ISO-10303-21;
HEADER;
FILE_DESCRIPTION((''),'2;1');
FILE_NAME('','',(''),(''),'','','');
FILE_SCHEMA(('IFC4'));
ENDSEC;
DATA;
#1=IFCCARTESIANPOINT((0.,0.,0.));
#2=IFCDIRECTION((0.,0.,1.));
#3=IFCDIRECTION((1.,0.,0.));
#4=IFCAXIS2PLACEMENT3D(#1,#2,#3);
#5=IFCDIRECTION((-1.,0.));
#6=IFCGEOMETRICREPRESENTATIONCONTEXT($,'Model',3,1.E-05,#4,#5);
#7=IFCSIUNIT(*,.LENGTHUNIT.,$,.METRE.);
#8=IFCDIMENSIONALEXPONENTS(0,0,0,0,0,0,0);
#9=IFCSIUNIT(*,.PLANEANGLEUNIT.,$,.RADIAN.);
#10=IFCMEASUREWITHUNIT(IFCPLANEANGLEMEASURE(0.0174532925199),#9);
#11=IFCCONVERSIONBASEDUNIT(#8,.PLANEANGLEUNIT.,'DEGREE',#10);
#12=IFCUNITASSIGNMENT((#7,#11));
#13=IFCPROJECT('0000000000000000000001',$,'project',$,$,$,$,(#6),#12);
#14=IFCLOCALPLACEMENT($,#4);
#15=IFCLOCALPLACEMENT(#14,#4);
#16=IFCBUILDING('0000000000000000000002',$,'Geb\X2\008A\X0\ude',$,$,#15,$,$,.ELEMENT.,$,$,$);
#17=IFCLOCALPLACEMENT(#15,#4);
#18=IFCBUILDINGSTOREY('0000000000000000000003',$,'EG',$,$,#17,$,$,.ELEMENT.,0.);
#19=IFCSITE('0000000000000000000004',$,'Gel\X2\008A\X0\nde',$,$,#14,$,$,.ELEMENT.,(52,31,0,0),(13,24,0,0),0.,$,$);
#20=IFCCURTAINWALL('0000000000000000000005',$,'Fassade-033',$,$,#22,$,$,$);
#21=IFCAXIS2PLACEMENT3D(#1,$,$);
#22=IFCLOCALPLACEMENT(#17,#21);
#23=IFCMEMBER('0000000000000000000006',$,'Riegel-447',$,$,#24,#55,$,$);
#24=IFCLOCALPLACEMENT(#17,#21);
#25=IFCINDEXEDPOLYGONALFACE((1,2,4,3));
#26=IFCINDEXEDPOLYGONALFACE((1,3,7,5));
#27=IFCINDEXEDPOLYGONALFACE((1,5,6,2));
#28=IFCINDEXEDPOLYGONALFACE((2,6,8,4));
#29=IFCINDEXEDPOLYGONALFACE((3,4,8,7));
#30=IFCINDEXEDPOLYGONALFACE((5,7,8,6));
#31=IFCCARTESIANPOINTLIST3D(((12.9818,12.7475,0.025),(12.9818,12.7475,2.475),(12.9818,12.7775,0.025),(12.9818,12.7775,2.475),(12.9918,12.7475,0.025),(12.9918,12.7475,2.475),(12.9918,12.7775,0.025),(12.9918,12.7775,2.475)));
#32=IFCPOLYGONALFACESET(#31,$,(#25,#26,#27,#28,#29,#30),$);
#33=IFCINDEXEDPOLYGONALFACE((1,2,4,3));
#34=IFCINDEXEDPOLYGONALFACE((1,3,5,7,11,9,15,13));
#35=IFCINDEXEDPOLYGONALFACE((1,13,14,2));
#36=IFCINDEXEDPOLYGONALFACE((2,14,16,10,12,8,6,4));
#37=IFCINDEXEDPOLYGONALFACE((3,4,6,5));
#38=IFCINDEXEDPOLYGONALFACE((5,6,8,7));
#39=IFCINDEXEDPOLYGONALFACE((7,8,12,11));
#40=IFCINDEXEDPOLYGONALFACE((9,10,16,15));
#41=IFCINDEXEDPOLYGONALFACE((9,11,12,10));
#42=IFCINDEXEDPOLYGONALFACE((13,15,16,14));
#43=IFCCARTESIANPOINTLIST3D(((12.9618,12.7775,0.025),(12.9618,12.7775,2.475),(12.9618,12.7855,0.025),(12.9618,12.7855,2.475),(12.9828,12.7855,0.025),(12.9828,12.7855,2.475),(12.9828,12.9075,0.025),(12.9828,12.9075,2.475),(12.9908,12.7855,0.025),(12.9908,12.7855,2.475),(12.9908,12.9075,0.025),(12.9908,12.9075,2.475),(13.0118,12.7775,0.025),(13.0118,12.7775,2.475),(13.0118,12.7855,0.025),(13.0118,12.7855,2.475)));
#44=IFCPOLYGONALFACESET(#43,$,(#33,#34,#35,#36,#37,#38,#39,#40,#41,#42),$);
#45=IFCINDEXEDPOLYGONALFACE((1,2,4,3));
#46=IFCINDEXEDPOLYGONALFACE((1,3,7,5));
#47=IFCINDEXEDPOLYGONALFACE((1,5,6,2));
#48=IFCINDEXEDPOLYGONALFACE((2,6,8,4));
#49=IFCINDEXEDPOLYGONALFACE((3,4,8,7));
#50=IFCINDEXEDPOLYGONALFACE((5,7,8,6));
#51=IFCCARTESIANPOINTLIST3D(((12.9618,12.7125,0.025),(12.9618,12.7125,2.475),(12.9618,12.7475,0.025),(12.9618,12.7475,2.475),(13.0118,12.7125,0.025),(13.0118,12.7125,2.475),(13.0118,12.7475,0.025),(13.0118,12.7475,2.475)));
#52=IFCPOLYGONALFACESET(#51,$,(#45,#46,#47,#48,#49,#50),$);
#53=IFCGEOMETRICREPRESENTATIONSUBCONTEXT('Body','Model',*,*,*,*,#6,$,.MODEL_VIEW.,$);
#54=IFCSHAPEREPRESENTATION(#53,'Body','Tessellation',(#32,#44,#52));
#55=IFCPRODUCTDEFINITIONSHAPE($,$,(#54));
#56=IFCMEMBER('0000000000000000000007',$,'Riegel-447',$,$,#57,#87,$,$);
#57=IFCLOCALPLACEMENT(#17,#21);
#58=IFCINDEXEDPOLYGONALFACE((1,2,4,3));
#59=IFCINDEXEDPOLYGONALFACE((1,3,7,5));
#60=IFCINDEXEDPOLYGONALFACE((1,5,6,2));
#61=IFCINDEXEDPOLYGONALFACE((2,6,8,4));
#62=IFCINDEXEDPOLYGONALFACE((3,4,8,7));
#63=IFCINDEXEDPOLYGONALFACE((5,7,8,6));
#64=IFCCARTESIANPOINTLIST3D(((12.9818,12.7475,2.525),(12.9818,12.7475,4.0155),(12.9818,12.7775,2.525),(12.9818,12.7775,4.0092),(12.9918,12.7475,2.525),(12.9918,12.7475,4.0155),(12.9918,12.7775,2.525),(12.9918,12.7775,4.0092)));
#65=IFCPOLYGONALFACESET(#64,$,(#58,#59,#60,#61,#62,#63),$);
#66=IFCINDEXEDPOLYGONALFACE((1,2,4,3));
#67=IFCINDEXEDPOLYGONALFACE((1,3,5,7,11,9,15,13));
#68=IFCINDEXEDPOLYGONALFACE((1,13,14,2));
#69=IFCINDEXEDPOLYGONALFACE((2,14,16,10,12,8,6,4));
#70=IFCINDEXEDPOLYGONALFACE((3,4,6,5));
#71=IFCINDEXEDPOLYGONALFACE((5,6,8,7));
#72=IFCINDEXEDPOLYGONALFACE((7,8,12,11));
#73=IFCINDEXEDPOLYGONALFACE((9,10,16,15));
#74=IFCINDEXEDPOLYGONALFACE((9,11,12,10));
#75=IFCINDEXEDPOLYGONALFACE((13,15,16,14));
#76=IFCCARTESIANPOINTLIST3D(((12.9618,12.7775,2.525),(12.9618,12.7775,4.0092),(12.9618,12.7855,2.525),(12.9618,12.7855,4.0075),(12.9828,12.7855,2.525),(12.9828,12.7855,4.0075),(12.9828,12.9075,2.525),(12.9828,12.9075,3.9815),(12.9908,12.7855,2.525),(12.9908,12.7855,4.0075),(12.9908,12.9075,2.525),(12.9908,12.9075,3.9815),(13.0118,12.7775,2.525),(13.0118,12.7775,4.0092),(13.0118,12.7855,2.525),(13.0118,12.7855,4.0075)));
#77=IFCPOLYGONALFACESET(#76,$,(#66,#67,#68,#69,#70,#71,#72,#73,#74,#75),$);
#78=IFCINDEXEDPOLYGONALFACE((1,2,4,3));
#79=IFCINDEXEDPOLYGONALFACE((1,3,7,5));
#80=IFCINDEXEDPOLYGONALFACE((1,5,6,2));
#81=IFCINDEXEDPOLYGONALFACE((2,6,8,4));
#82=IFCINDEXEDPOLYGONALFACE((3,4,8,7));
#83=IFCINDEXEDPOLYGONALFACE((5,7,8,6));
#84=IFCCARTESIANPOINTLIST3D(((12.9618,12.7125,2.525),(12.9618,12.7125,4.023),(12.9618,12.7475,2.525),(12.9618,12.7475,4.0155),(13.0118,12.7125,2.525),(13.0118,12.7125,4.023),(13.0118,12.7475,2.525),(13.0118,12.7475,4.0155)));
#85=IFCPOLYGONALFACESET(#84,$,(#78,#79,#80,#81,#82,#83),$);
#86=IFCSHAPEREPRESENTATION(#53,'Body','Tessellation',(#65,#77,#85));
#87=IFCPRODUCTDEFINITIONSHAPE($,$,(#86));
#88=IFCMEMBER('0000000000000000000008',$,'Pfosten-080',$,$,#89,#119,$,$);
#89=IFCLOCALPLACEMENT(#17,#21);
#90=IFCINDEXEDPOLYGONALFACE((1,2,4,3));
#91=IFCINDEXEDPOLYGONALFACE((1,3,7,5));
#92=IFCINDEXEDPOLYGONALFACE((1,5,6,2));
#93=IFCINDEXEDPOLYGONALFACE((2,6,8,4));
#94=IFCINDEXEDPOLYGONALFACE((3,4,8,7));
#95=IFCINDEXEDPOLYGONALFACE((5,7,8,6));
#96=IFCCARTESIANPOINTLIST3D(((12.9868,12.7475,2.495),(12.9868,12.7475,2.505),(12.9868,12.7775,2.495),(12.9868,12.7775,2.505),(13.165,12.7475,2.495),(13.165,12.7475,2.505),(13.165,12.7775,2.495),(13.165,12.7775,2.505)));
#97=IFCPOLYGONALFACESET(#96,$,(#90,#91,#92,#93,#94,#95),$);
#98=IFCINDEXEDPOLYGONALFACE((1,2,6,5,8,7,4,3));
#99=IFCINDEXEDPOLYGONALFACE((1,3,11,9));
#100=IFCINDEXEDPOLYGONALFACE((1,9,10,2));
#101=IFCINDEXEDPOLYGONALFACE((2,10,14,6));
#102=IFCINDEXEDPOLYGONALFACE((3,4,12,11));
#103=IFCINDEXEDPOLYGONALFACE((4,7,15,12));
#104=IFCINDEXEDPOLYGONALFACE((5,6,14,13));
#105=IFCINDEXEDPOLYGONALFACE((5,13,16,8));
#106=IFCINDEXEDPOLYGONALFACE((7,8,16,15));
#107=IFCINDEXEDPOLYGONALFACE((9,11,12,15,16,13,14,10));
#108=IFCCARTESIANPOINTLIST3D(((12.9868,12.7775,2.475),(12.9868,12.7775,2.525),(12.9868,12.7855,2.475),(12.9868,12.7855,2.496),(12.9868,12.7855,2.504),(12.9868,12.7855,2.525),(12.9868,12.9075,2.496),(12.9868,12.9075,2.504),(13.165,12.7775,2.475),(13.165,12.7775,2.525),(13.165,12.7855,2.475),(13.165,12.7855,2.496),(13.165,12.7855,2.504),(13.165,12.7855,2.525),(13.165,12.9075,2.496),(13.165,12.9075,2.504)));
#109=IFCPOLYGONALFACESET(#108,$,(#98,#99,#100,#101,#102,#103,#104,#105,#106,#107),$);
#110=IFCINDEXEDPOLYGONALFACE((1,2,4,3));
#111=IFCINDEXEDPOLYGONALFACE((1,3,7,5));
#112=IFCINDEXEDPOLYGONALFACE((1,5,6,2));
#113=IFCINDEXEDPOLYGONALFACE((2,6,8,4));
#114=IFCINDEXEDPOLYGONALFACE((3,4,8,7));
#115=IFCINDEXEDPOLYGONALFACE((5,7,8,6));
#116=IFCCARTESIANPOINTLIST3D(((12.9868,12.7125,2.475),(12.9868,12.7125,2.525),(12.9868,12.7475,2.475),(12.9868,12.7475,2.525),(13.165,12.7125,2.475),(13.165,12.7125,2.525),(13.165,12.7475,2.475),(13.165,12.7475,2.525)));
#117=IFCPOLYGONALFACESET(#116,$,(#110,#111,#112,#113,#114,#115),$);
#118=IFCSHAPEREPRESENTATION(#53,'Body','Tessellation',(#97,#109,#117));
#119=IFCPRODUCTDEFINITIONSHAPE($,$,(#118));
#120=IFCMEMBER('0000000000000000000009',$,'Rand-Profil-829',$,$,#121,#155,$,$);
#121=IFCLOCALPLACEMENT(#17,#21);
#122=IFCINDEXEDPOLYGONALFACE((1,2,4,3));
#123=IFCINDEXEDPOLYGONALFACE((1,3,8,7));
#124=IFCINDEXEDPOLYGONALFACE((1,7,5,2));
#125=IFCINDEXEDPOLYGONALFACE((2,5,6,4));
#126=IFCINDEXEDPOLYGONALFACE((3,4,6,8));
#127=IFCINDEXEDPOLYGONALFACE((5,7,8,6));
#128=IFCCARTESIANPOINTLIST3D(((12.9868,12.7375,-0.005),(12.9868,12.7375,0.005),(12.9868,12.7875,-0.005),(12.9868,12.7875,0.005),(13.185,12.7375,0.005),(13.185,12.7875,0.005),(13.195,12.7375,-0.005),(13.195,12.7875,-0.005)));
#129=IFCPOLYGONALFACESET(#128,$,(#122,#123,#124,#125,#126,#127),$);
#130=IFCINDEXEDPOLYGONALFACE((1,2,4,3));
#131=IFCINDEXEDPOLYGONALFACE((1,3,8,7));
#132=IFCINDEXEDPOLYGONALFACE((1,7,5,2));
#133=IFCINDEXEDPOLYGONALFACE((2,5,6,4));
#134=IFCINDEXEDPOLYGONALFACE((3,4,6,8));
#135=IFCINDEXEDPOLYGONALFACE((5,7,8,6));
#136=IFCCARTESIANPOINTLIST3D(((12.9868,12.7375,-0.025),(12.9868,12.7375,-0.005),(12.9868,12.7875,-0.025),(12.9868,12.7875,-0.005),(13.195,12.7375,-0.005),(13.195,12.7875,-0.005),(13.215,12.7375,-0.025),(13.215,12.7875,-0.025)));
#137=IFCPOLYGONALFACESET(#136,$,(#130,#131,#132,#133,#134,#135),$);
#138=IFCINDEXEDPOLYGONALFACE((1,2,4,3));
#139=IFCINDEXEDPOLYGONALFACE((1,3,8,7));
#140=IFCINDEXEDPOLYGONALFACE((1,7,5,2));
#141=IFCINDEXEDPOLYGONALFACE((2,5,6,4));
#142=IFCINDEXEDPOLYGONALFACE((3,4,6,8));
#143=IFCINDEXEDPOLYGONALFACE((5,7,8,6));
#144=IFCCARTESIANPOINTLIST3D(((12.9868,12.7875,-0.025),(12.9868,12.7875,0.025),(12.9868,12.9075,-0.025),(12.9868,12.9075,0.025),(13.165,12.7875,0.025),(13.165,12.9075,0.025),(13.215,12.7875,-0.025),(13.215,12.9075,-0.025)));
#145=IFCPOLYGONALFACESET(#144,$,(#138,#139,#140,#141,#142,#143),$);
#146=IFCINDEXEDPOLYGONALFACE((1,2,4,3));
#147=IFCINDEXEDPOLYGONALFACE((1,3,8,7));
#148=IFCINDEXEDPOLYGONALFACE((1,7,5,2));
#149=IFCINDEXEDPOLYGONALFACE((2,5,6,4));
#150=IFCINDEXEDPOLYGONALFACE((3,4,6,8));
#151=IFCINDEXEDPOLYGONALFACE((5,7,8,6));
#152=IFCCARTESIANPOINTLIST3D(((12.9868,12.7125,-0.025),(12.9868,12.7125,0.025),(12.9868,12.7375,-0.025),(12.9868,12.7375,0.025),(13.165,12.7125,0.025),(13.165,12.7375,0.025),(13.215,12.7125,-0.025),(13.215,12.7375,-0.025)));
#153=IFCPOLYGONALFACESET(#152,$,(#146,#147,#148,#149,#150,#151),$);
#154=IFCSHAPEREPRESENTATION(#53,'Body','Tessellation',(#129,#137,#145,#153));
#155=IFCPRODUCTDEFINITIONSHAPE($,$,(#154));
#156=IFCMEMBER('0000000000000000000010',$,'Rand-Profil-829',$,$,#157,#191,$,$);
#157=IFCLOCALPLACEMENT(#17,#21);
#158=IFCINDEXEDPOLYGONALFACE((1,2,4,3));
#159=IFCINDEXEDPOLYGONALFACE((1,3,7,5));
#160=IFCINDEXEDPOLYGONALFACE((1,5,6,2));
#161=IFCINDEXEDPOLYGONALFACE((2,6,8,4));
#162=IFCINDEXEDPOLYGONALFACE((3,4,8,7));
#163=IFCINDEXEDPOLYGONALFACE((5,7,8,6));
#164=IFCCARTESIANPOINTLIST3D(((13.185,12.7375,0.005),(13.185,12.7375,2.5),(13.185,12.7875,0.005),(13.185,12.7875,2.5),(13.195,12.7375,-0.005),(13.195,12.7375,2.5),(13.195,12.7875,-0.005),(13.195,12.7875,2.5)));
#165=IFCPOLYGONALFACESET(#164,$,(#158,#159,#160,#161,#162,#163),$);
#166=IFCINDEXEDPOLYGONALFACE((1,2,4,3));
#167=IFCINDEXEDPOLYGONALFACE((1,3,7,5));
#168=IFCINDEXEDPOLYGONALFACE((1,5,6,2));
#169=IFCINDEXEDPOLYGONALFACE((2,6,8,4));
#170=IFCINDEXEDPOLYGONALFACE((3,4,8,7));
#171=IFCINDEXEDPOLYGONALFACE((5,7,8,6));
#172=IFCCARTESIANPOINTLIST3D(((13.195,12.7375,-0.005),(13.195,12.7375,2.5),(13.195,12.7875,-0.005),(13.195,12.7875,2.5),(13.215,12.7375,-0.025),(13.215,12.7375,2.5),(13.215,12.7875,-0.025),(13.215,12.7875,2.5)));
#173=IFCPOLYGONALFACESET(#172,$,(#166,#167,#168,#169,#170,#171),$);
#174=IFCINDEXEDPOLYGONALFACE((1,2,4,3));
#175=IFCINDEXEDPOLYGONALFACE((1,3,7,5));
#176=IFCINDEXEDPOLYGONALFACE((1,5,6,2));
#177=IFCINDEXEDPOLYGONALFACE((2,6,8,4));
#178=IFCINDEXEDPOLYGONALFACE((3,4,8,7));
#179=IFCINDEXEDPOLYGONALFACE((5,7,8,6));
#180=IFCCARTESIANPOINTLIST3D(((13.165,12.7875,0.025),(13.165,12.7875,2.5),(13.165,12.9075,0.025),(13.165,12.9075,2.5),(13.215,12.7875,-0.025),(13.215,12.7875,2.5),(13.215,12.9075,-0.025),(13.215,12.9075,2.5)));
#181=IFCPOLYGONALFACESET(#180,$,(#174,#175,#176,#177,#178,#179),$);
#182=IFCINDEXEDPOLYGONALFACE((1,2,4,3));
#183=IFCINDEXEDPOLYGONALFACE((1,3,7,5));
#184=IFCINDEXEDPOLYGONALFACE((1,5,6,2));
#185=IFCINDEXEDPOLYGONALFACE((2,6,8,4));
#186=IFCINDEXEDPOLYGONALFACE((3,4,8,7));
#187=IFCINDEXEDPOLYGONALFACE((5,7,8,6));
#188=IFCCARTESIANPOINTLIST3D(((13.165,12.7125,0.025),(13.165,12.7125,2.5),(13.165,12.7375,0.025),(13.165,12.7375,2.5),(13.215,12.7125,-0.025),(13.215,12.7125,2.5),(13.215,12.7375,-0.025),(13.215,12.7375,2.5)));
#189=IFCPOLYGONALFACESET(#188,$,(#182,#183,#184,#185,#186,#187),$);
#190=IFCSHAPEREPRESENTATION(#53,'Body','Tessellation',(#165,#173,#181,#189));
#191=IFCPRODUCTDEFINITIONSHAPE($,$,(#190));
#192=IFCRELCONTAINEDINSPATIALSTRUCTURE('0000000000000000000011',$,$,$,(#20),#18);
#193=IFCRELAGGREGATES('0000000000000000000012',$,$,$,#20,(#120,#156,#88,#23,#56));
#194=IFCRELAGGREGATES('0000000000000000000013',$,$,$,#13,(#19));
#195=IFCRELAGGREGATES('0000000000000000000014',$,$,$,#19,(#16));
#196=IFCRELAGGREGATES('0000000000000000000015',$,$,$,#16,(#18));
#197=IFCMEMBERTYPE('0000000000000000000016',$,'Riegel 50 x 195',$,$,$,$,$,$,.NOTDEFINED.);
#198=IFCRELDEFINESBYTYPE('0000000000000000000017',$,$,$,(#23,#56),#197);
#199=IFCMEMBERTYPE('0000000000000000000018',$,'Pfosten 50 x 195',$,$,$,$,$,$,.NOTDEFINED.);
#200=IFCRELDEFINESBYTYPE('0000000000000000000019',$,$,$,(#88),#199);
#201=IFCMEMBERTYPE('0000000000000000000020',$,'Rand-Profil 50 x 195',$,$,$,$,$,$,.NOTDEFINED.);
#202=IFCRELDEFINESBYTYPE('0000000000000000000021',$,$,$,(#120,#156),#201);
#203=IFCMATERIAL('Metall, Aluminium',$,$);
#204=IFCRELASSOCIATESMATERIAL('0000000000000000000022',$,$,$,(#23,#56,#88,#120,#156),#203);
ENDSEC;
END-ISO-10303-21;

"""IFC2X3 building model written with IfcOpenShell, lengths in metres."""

from ifc_helpers import new_model, entity, si_unit, converted_unit, direction, frame, origin_with_axes, place, context, subcontext, project, spatial, polyline, outline, extrude, clip, halfspace, material, type_object, element, aggregate, save


model = new_model("IFC2X3")

# Units and contexts
model_context = context("Model", 3, precision=1e-05, world=origin_with_axes(), true_north=direction((-1.0, 0.0)))
body_context = subcontext(model_context, "Body", "Model", "MODEL_VIEW")
ifc_project = project(units=[si_unit("LENGTHUNIT", "METRE"), converted_unit("PLANEANGLEUNIT", "DEGREE", entity("IfcPlaneAngleMeasure", 0.0174532925199), si_unit("PLANEANGLEUNIT", "RADIAN"), dimensions=[0, 0, 0, 0, 0, 0, 0])], contexts=[model_context])

# Site, building, storey
site_placement = place(None, origin_with_axes())
site = spatial("IfcSite", under=ifc_project, at=site_placement, Name="Gel\u008ande", CompositionType="ELEMENT", RefLatitude=(52, 31, 0, 0), RefLongitude=(13, 24, 0, 0), RefElevation=0.0)
building_placement = place(site_placement, origin_with_axes())
building = spatial("IfcBuilding", under=site, at=building_placement, Name="Geb\u008aude", CompositionType="ELEMENT")
storey_placement = place(building_placement, origin_with_axes())
storey = spatial("IfcBuildingStorey", under=building, at=storey_placement, Name="EG", CompositionType="ELEMENT", Elevation=0.0)

# Curtain wall, members
curtain_wall_1_placement = place(storey_placement, frame((12.3938, 12.7625, 0.0), z_axis=(0.0, 0.0, 1.0), x_axis=(1.0, 0.0, 0.0)))
curtain_wall_1 = element("IfcCurtainWall", 1, at=curtain_wall_1_placement, inside=storey, Name="Fassade-033")
ifc_material_1 = material(Name="Metall, Aluminium")
member_type_1 = type_object("IfcMemberType", Name="Riegel 50 x 195", PredefinedType="NOTDEFINED")
member_1_placement = place(curtain_wall_1_placement, frame((0.593, 0.0, 0.0), z_axis=(0.0, 0.0, 1.0), x_axis=(-1.0, 0.0, 0.0)))
member_1 = element("IfcMember", 2, at=member_1_placement, type_object=member_type_1, material=ifc_material_1, Name="Riegel-447", context=body_context, shape_type="SweptSolid", body=[
    extrude(outline(polyline([(-0.005, 0.015), (-0.005, -0.015), (0.005, -0.015), (0.005, 0.015), (-0.005, 0.015)])), frame((0.0, 0.0, 0.025), z_axis=(0.0, 0.0, 1.0), x_axis=(-1.0, 0.0, 0.0)), (0.0, 0.0, 1.0), 2.45),
    extrude(outline(polyline([(-0.004, 0.145), (-0.004, 0.023), (-0.025, 0.023), (-0.025, 0.015), (0.025, 0.015), (0.025, 0.023), (0.004, 0.023), (0.004, 0.145), (-0.004, 0.145)])), frame((0.0, 0.0, 0.025), z_axis=(0.0, 0.0, 1.0), x_axis=(-1.0, 0.0, 0.0)), (0.0, 0.0, 1.0), 2.45),
    extrude(outline(polyline([(0.025, -0.05), (0.025, -0.015), (-0.025, -0.015), (-0.025, -0.05), (0.025, -0.05)])), frame((0.0, 0.0, 0.025), z_axis=(0.0, 0.0, 1.0), x_axis=(-1.0, 0.0, 0.0)), (0.0, 0.0, 1.0), 2.45),
])
member_2_placement = place(curtain_wall_1_placement, frame((0.593, 0.0, 2.5), z_axis=(0.0, 0.0, 1.0), x_axis=(-1.0, 0.0, 0.0)))
member_2 = element("IfcMember", 3, at=member_2_placement, type_object=member_type_1, material=ifc_material_1, Name="Riegel-447", context=body_context, shape_type="Clipping", body=[
    clip(extrude(outline(polyline([(0.005, 0.015), (-0.005, 0.015), (-0.005, -0.015), (0.005, -0.015), (0.005, 0.015)])), frame((0.0, 0.0, 0.025), z_axis=(0.0, 0.0, 1.0), x_axis=(-1.0, 0.0, 0.0)), (0.0, 0.0, 1.0), 1.4905), halfspace(frame((0.0, -0.3076, 1.447), z_axis=(0.0, 0.207912, -0.978148), x_axis=(0.0, -0.978148, -0.207912)), True)),
    clip(extrude(outline(polyline([(0.025, 0.023), (0.004, 0.023), (0.004, 0.145), (-0.004, 0.145), (-0.004, 0.023), (-0.025, 0.023), (-0.025, 0.015), (0.025, 0.015), (0.025, 0.023)])), frame((0.0, 0.0, 0.025), z_axis=(0.0, 0.0, 1.0), x_axis=(-1.0, 0.0, 0.0)), (0.0, 0.0, 1.0), 1.4842), halfspace(frame((0.0, -0.3076, 1.447), z_axis=(0.0, 0.207912, -0.978148), x_axis=(0.0, -0.978148, -0.207912)), True)),
    clip(extrude(outline(polyline([(0.025, -0.015), (-0.025, -0.015), (-0.025, -0.05), (0.025, -0.05), (0.025, -0.015)])), frame((0.0, 0.0, 0.025), z_axis=(0.0, 0.0, 1.0), x_axis=(-1.0, 0.0, 0.0)), (0.0, 0.0, 1.0), 1.498), halfspace(frame((0.0, -0.3076, 1.447), z_axis=(0.0, 0.207912, -0.978148), x_axis=(0.0, -0.978148, -0.207912)), True)),
])
member_type_2 = type_object("IfcMemberType", Name="Pfosten 50 x 195", PredefinedType="NOTDEFINED")
member_3_placement = place(curtain_wall_1_placement, frame((0.593, 0.0, 2.5), z_axis=(1.0, 0.0, 0.0), x_axis=(0.0, 0.0, 1.0)))
member_3 = element("IfcMember", 4, at=member_3_placement, type_object=member_type_2, material=ifc_material_1, Name="Pfosten-080", context=body_context, shape_type="SweptSolid", body=[
    extrude(outline(polyline([(-0.015, -0.005), (0.015, -0.005), (0.015, 0.005), (-0.015, 0.005), (-0.015, -0.005)])), frame((0.0, 0.0, 0.0), z_axis=(0.0, 0.0, 1.0), x_axis=(0.0, 1.0, 0.0)), (0.0, 0.0, 1.0), 0.1782),
    extrude(outline(polyline([(-0.145, -0.004), (-0.023, -0.004), (-0.023, -0.025), (-0.015, -0.025), (-0.015, 0.025), (-0.023, 0.025), (-0.023, 0.004), (-0.145, 0.004), (-0.145, -0.004)])), frame((0.0, 0.0, 0.0), z_axis=(0.0, 0.0, 1.0), x_axis=(0.0, 1.0, 0.0)), (0.0, 0.0, 1.0), 0.1782),
    extrude(outline(polyline([(0.05, 0.025), (0.015, 0.025), (0.015, -0.025), (0.05, -0.025), (0.05, 0.025)])), frame((0.0, 0.0, 0.0), z_axis=(0.0, 0.0, 1.0), x_axis=(0.0, 1.0, 0.0)), (0.0, 0.0, 1.0), 0.1782),
])
member_type_3 = type_object("IfcMemberType", Name="Rand-Profil 50 x 195", PredefinedType="NOTDEFINED")
member_4_placement = place(curtain_wall_1_placement, frame((0.593, 0.0, 0.0), z_axis=(1.0, 0.0, 0.0), x_axis=(0.0, 0.0, 1.0)))
member_4 = element("IfcMember", 5, at=member_4_placement, type_object=member_type_3, material=ifc_material_1, Name="Rand-Profil-829", context=body_context, shape_type="Clipping", body=[
    clip(extrude(outline(polyline([(-0.025, -0.005), (0.025, -0.005), (0.025, 0.005), (-0.025, 0.005), (-0.025, -0.005)])), frame((0.0, 0.0, 0.0), z_axis=(0.0, 0.0, 1.0), x_axis=(0.0, 1.0, 0.0)), (0.0, 0.0, 1.0), 0.2082), halfspace(frame((0.1016, 0.0, 0.1016), z_axis=(-0.707107, 0.0, -0.707107), x_axis=(0.707107, 0.0, -0.707107)), True)),
    clip(extrude(outline(polyline([(-0.025, 0.005), (0.025, 0.005), (0.025, 0.025), (-0.025, 0.025), (-0.025, 0.005)])), frame((0.0, 0.0, 0.0), z_axis=(0.0, 0.0, 1.0), x_axis=(0.0, 1.0, 0.0)), (0.0, 0.0, 1.0), 0.2282), halfspace(frame((0.1016, 0.0, 0.1016), z_axis=(-0.707107, 0.0, -0.707107), x_axis=(0.707107, 0.0, -0.707107)), True)),
    clip(extrude(outline(polyline([(-0.145, -0.025), (-0.025, -0.025), (-0.025, 0.025), (-0.145, 0.025), (-0.145, -0.025)])), frame((0.0, 0.0, 0.0), z_axis=(0.0, 0.0, 1.0), x_axis=(0.0, 1.0, 0.0)), (0.0, 0.0, 1.0), 0.2282), halfspace(frame((0.1016, 0.0, 0.1016), z_axis=(-0.707107, 0.0, -0.707107), x_axis=(0.707107, 0.0, -0.707107)), True)),
    clip(extrude(outline(polyline([(0.05, 0.025), (0.025, 0.025), (0.025, -0.025), (0.05, -0.025), (0.05, 0.025)])), frame((0.0, 0.0, 0.0), z_axis=(0.0, 0.0, 1.0), x_axis=(0.0, 1.0, 0.0)), (0.0, 0.0, 1.0), 0.2282), halfspace(frame((0.1016, 0.0, 0.1016), z_axis=(-0.707107, 0.0, -0.707107), x_axis=(0.707107, 0.0, -0.707107)), True)),
])
member_5_placement = place(curtain_wall_1_placement, frame((0.7962, 0.0, 0.0), z_axis=(0.0, 0.0, 1.0), x_axis=(-1.0, 0.0, 0.0)))
member_5 = element("IfcMember", 6, at=member_5_placement, type_object=member_type_3, material=ifc_material_1, Name="Rand-Profil-829", context=body_context, shape_type="Clipping", body=[
    clip(extrude(outline(polyline([(-0.005, 0.025), (-0.005, -0.025), (0.005, -0.025), (0.005, 0.025), (-0.005, 0.025)])), frame((0.0, 0.0, -0.005), z_axis=(0.0, 0.0, 1.0), x_axis=(-1.0, 0.0, 0.0)), (0.0, 0.0, 1.0), 2.505), halfspace(frame((0.0, 0.0, 0.0), z_axis=(-0.707107, 0.0, 0.707107), x_axis=(-0.707107, 0.0, -0.707107)), True)),
    clip(extrude(outline(polyline([(0.005, 0.025), (0.005, -0.025), (0.025, -0.025), (0.025, 0.025), (0.005, 0.025)])), frame((0.0, 0.0, -0.025), z_axis=(0.0, 0.0, 1.0), x_axis=(-1.0, 0.0, 0.0)), (0.0, 0.0, 1.0), 2.525), halfspace(frame((0.0, 0.0, 0.0), z_axis=(-0.707107, 0.0, 0.707107), x_axis=(-0.707107, 0.0, -0.707107)), True)),
    clip(extrude(outline(polyline([(-0.025, 0.145), (-0.025, 0.025), (0.025, 0.025), (0.025, 0.145), (-0.025, 0.145)])), frame((0.0, 0.0, -0.025), z_axis=(0.0, 0.0, 1.0), x_axis=(-1.0, 0.0, 0.0)), (0.0, 0.0, 1.0), 2.525), halfspace(frame((0.0, 0.0, 0.0), z_axis=(-0.707107, 0.0, 0.707107), x_axis=(-0.707107, 0.0, -0.707107)), True)),
    clip(extrude(outline(polyline([(0.025, -0.05), (0.025, -0.025), (-0.025, -0.025), (-0.025, -0.05), (0.025, -0.05)])), frame((0.0, 0.0, -0.025), z_axis=(0.0, 0.0, 1.0), x_axis=(-1.0, 0.0, 0.0)), (0.0, 0.0, 1.0), 2.525), halfspace(frame((0.0, 0.0, 0.0), z_axis=(-0.707107, 0.0, 0.707107), x_axis=(-0.707107, 0.0, -0.707107)), True)),
])

aggregate(curtain_wall_1, [member_4, member_5, member_3, member_1, member_2])

save(model, "model.ifc")
